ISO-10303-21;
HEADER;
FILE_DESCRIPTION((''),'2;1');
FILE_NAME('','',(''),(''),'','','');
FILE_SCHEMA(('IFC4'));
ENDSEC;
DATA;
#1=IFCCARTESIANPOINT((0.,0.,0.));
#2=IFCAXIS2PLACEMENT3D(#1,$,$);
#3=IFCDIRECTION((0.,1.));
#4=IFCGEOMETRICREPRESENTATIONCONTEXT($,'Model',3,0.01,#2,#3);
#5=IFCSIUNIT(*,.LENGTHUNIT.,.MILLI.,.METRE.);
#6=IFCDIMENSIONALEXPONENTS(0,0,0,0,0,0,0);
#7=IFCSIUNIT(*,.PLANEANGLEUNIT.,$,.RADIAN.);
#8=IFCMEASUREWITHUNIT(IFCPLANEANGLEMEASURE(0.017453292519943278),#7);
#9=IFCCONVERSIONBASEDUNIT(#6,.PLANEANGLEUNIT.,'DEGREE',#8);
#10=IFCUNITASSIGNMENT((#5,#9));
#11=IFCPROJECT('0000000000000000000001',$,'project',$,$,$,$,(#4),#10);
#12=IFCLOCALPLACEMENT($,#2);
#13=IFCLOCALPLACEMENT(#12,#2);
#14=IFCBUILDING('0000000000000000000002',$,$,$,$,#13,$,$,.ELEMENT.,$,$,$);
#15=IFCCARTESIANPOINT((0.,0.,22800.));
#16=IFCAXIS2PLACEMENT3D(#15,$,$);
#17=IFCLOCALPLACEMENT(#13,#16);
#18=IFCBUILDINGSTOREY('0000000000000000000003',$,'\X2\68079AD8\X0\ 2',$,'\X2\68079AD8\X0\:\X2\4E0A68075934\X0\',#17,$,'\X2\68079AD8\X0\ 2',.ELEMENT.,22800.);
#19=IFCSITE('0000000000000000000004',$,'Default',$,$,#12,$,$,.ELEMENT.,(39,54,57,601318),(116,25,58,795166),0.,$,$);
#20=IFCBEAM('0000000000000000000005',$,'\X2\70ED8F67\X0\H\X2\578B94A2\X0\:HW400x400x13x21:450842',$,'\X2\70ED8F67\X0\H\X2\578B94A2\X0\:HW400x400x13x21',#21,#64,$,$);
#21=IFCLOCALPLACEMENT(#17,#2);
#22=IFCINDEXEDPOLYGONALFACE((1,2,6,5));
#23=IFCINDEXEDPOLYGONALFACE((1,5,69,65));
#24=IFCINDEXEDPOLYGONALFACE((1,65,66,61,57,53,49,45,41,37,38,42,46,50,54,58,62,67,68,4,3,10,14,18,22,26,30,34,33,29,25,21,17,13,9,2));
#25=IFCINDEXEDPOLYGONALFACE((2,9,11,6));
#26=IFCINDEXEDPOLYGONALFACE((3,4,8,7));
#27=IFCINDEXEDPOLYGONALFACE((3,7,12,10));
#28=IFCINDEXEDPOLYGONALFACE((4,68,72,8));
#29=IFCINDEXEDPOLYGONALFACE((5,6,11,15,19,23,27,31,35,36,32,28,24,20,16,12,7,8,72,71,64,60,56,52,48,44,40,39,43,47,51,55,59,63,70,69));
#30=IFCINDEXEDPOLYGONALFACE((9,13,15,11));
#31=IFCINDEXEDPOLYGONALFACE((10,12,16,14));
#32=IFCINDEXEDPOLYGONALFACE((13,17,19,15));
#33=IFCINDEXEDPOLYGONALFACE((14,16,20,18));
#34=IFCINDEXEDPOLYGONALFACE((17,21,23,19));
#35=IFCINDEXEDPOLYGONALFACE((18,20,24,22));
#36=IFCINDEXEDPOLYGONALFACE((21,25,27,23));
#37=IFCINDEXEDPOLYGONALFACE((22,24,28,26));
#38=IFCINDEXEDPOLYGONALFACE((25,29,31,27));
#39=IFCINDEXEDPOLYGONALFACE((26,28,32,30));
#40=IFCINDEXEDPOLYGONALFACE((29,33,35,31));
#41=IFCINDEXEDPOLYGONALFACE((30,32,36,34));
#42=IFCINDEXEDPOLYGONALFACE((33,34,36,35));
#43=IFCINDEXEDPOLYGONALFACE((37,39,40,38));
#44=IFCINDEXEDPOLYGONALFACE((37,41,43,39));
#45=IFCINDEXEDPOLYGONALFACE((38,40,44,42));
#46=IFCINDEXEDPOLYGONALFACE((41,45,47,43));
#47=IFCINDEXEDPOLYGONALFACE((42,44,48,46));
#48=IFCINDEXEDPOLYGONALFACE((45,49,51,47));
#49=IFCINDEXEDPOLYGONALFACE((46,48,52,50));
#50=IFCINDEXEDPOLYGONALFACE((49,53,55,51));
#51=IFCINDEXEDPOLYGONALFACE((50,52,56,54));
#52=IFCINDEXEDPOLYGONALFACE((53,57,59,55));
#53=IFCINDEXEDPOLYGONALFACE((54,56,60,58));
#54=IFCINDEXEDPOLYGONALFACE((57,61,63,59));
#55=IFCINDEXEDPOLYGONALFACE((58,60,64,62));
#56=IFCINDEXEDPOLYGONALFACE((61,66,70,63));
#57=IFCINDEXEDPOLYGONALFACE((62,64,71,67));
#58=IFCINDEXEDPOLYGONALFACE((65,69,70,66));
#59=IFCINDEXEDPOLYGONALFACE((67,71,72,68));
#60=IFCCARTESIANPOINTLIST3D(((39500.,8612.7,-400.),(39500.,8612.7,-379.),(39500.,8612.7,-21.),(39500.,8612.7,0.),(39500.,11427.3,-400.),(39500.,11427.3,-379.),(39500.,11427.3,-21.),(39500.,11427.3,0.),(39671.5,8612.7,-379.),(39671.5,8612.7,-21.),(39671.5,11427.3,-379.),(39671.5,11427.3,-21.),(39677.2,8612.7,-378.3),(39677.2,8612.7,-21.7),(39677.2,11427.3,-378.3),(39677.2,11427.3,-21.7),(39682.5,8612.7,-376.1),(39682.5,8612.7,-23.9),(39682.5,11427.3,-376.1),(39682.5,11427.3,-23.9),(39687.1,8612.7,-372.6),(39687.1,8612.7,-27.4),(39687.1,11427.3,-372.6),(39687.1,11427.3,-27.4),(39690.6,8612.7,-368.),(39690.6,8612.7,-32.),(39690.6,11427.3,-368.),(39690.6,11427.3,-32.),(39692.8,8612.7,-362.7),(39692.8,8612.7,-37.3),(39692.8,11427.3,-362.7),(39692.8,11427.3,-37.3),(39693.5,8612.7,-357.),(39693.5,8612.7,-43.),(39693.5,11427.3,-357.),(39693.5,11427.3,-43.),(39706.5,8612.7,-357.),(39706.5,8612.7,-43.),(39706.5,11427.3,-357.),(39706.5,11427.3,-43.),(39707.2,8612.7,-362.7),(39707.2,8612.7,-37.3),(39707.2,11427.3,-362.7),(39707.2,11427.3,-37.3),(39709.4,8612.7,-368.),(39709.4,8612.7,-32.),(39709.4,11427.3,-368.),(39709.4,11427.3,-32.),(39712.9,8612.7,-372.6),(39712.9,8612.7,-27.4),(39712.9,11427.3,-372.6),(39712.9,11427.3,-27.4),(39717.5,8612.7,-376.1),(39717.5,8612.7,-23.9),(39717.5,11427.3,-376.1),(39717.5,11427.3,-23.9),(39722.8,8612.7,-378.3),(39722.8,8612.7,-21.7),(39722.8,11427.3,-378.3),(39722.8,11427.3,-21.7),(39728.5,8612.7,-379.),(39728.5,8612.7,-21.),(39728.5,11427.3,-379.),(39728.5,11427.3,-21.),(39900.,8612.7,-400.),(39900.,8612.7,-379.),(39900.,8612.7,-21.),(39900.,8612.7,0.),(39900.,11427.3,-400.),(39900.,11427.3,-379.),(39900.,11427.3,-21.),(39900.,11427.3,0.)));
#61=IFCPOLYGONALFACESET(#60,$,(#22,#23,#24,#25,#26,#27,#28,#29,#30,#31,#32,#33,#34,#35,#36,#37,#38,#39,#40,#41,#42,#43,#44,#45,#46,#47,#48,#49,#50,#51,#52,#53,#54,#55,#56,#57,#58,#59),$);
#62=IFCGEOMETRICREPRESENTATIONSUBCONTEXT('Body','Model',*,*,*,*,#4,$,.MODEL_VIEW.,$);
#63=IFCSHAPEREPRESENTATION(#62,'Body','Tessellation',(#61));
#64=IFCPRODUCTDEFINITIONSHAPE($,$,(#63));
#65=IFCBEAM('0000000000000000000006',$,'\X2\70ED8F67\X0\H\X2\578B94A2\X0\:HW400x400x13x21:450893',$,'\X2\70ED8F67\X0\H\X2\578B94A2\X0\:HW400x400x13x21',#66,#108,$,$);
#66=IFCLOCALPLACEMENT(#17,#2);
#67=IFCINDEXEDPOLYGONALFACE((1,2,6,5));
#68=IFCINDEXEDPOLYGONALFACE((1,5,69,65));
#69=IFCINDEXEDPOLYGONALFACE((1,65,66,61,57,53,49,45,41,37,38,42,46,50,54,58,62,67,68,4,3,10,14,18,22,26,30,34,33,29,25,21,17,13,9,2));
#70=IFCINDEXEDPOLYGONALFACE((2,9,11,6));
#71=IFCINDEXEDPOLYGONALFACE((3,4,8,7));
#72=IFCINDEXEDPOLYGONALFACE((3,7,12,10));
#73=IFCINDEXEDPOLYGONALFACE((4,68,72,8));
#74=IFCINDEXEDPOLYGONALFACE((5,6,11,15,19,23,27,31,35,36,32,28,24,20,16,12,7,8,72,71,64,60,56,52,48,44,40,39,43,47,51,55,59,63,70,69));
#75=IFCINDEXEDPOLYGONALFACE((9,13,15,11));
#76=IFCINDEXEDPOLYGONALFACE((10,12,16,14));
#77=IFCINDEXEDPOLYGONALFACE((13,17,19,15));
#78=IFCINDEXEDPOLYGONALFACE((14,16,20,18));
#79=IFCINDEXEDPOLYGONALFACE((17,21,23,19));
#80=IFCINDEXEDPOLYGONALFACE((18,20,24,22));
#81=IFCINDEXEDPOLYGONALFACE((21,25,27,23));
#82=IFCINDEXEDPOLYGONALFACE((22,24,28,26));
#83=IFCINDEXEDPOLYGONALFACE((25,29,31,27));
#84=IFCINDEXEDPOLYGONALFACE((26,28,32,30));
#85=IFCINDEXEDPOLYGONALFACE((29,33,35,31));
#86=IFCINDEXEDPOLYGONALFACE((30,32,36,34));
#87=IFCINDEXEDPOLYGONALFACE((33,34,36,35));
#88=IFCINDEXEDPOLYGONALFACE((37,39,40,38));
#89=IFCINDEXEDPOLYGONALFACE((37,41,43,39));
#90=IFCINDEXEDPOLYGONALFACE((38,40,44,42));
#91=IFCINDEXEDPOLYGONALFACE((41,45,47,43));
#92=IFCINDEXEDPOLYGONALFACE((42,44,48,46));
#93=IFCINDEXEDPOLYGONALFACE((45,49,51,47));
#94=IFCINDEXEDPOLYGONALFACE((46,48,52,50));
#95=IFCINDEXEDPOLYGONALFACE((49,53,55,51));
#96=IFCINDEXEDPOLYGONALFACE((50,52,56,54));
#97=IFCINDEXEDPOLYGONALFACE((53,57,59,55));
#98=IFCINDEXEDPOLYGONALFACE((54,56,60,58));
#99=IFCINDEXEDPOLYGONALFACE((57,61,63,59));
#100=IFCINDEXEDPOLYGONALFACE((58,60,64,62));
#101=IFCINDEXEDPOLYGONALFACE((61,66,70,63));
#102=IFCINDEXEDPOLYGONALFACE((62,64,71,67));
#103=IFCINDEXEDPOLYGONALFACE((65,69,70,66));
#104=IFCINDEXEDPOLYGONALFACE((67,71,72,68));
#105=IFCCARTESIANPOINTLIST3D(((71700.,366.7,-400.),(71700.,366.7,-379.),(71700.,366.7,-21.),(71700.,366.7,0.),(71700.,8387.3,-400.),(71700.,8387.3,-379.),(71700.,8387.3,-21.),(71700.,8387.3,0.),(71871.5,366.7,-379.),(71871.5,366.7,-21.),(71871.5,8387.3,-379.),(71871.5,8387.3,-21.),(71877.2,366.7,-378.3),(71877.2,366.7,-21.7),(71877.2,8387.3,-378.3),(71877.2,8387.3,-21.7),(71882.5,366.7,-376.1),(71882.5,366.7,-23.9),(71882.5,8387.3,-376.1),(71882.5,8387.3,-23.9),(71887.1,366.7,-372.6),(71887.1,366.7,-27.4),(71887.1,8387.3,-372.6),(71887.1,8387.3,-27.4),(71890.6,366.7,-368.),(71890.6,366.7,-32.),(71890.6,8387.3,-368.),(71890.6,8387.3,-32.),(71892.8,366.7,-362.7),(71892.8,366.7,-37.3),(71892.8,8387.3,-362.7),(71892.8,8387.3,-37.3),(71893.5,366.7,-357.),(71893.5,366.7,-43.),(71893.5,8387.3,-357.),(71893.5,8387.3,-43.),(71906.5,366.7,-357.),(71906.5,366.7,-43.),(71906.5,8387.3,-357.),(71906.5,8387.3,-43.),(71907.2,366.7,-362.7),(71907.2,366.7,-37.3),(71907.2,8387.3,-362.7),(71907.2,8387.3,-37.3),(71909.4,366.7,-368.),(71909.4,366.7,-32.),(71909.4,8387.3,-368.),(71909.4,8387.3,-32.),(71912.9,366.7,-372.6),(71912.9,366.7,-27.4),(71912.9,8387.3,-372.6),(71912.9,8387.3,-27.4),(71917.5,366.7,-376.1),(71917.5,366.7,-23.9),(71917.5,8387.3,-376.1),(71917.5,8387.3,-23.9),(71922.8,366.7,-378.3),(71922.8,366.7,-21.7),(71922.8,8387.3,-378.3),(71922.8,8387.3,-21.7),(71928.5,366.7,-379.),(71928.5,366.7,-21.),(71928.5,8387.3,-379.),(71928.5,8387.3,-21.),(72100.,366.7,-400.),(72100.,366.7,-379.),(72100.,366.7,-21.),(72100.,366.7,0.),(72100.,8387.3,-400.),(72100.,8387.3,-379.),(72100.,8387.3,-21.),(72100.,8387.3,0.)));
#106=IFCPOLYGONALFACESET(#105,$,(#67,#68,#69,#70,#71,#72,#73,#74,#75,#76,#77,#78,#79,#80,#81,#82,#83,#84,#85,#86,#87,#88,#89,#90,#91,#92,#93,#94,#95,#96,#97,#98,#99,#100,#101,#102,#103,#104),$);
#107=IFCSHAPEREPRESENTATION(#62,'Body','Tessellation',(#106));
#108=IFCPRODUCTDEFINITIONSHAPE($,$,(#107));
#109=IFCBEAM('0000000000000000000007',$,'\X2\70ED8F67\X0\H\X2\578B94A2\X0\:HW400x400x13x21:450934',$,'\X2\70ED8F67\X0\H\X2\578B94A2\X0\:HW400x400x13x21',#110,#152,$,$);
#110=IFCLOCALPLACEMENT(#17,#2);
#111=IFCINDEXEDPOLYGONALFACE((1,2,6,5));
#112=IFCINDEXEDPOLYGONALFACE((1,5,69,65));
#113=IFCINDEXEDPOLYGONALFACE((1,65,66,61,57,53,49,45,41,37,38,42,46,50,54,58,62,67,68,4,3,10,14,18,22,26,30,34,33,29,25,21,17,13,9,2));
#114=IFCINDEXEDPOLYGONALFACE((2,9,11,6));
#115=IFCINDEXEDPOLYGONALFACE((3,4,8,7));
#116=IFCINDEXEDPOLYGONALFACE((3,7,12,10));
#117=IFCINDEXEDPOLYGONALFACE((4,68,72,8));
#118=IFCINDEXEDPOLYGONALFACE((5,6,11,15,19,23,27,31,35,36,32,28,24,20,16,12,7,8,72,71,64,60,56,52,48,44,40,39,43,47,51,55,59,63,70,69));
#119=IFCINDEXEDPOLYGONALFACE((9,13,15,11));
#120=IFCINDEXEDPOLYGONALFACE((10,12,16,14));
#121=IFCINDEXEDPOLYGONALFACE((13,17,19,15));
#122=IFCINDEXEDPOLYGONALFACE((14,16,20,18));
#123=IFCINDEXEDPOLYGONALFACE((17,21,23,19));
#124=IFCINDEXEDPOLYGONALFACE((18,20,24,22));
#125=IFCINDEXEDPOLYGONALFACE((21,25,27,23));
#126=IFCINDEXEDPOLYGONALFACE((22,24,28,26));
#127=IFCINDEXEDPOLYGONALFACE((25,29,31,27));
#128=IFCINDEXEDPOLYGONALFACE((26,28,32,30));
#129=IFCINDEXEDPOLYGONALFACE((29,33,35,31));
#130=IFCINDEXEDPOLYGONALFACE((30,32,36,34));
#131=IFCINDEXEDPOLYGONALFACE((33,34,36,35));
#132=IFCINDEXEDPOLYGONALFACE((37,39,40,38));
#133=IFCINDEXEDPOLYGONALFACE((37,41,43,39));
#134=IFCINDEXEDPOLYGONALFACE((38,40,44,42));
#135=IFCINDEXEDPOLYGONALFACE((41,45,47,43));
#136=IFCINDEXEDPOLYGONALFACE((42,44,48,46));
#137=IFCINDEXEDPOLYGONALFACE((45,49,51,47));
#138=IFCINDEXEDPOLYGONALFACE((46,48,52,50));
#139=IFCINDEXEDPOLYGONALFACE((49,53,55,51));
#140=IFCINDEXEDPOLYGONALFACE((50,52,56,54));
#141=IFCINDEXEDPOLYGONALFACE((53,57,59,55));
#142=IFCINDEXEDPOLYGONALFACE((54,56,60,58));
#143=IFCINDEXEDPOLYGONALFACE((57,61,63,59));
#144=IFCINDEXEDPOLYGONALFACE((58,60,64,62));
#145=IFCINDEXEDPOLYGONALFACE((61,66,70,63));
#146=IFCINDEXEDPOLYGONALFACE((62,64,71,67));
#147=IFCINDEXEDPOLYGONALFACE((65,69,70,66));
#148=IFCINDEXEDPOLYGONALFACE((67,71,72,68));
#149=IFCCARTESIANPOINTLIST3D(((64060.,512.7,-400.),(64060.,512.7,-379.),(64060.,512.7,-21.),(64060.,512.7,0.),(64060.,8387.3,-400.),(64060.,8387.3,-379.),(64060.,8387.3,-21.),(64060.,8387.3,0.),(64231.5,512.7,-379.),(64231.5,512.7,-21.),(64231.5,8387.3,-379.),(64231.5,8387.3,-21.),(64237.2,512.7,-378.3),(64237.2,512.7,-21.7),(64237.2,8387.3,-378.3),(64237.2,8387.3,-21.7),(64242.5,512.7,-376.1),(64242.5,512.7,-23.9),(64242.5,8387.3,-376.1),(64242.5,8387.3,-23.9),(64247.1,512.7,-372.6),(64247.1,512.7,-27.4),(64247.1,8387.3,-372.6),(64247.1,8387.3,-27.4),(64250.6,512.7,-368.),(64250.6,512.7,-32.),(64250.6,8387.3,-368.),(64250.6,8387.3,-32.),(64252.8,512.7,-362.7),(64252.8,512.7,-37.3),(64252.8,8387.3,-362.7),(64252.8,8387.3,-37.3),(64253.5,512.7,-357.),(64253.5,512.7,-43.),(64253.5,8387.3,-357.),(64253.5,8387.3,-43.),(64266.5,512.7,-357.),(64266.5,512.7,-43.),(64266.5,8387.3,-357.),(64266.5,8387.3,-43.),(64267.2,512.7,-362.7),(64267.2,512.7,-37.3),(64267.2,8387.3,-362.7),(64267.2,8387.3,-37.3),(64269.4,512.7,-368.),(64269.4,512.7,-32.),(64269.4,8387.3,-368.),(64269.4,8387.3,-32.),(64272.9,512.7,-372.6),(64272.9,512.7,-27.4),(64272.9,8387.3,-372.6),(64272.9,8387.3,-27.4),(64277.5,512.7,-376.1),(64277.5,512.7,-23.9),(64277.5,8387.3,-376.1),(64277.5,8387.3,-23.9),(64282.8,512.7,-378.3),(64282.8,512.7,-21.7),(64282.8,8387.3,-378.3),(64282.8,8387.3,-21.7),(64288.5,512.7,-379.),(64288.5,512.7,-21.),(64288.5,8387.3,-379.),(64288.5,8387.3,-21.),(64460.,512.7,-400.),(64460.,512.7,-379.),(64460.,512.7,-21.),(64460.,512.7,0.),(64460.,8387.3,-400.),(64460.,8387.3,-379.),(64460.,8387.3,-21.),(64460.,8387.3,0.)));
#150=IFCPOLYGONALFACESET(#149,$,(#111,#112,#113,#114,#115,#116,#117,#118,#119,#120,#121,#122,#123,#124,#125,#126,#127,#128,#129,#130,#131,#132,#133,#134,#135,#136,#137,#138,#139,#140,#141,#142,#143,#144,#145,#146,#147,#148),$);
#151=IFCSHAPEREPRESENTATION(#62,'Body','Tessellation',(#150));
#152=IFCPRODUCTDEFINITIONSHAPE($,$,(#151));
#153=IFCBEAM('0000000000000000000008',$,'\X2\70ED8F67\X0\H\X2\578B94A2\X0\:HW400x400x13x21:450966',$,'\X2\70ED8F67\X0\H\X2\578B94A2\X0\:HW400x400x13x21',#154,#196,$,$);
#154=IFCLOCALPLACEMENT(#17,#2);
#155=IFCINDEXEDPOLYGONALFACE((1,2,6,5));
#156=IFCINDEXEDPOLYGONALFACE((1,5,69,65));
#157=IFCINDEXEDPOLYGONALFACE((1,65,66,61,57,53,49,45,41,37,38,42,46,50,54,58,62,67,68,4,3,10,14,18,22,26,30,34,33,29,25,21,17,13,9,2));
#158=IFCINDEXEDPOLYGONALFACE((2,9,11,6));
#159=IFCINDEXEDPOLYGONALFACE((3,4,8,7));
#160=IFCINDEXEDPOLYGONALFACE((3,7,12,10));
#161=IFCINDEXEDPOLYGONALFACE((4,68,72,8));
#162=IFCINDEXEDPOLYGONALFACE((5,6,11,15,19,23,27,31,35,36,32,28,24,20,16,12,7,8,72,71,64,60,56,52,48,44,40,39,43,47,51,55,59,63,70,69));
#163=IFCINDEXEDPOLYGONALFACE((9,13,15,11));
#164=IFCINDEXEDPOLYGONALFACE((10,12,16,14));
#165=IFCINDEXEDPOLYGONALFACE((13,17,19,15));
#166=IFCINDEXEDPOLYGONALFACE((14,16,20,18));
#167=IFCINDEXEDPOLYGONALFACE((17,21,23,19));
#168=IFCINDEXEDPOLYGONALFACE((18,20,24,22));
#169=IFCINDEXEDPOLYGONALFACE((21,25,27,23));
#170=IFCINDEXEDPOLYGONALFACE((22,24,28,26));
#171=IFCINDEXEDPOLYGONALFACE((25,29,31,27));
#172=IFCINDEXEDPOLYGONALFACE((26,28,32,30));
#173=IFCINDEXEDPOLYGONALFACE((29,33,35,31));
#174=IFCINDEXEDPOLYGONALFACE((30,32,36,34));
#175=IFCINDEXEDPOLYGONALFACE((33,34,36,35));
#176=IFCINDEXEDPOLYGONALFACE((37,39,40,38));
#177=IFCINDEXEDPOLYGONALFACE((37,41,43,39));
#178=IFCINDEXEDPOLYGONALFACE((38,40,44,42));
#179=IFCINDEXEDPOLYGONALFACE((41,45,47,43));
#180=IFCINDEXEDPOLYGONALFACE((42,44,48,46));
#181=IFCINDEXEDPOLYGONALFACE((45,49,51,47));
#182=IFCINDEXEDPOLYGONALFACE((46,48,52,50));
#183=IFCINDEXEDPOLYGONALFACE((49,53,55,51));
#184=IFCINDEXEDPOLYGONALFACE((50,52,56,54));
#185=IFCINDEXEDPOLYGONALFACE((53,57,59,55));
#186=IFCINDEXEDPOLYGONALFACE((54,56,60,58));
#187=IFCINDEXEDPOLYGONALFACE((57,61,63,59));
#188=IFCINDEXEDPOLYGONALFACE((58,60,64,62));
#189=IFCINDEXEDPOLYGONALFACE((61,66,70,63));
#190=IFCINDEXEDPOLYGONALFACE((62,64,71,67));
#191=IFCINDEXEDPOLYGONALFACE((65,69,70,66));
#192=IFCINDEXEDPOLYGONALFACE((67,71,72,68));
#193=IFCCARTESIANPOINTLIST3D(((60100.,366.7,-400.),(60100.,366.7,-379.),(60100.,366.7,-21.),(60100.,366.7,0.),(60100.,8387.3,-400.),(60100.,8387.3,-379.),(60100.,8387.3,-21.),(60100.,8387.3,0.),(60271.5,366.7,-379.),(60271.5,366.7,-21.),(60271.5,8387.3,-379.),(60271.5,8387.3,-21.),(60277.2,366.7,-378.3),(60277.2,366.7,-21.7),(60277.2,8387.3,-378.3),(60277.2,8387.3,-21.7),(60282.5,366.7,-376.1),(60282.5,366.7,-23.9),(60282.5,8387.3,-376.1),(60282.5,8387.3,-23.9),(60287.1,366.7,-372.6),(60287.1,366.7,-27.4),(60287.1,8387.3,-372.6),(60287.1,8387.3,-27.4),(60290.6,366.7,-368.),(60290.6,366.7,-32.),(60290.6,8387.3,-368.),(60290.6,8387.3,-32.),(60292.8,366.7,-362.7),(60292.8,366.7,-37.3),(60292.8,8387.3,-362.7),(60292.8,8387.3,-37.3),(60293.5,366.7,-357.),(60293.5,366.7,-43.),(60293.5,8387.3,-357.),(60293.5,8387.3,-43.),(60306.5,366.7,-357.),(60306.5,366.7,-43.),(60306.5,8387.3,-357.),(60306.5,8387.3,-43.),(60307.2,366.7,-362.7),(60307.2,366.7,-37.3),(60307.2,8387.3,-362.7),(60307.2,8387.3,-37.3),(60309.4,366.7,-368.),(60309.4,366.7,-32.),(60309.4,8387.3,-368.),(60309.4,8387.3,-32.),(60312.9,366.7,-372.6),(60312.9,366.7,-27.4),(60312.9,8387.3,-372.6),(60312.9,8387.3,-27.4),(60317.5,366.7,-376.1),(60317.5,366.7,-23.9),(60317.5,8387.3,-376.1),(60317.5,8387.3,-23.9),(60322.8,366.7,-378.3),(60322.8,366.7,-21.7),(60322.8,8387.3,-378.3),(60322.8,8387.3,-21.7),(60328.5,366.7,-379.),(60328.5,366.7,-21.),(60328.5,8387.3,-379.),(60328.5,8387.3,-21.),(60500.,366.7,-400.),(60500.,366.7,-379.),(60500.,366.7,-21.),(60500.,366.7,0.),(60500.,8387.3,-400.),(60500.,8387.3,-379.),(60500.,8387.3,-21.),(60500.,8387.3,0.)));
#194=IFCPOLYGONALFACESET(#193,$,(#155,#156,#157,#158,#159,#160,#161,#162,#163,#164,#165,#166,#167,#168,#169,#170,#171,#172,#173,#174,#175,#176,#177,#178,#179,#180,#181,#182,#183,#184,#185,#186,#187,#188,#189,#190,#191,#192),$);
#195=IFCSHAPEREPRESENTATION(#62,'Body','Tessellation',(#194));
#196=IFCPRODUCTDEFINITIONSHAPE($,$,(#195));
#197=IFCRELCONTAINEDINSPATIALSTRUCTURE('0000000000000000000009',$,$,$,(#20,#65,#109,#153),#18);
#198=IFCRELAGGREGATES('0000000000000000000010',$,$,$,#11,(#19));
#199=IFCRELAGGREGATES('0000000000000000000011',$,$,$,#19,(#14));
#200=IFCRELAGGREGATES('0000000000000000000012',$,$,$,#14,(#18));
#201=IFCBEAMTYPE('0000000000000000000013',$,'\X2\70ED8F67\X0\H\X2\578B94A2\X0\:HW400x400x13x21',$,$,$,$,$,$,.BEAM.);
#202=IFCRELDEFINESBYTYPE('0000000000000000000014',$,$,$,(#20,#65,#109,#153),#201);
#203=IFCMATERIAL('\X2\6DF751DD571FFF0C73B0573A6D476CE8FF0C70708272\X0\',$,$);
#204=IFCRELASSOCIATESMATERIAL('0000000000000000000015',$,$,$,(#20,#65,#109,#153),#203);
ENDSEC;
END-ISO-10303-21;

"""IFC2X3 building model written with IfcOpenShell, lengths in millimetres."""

from ifc_helpers import new_model, entity, si_unit, converted_unit, direction, frame, frame_2d, origin, place, context, subcontext, project, spatial, i_section, extrude, material, type_object, element, save


model = new_model("IFC2X3")

# Units and contexts
model_context = context("Model", 3, precision=0.01, world=origin(), true_north=direction((0.0, 1.0)))
body_context = subcontext(model_context, "Body", "Model", "MODEL_VIEW")
ifc_project = project(units=[si_unit("LENGTHUNIT", "METRE", prefix="MILLI"), converted_unit("PLANEANGLEUNIT", "DEGREE", entity("IfcPlaneAngleMeasure", 0.017453292519943278), si_unit("PLANEANGLEUNIT", "RADIAN"), dimensions=[0, 0, 0, 0, 0, 0, 0])], contexts=[model_context])

# Site, building, storey
site_placement = place(None, origin())
site = spatial("IfcSite", under=ifc_project, at=site_placement, Name="Default", CompositionType="ELEMENT", RefLatitude=(39, 54, 57, 601318), RefLongitude=(116, 25, 58, 795166), RefElevation=0.0)
building_placement = place(site_placement, origin())
building = spatial("IfcBuilding", under=site, at=building_placement, CompositionType="ELEMENT")
storey_placement = place(building_placement, frame((0.0, 0.0, 22800.0)))
storey = spatial("IfcBuildingStorey", under=building, at=storey_placement, Name="标高 2", ObjectType="标高:上标头", LongName="标高 2", CompositionType="ELEMENT", Elevation=22800.0)

# Beams
ifc_material = material(Name="混凝土，现场浇注，灰色")
beam_type = type_object("IfcBeamType", Name="热轧H型钢:HW400x400x13x21", PredefinedType="BEAM")
beam_1_placement = place(storey_placement, frame((39700.0, 11840.0, 0.0), z_axis=(0.0, 0.0, 1.0), x_axis=(0.0, -1.0, 0.0)))
element("IfcBeam", 1, at=beam_1_placement, inside=storey, type_object=beam_type, material=ifc_material, Name="热轧H型钢:HW400x400x13x21:450842", ObjectType="热轧H型钢:HW400x400x13x21", context=body_context, shape_type="SweptSolid", body=[
    extrude(i_section(OverallWidth=400.0, OverallDepth=400.0, WebThickness=13.0, FlangeThickness=21.0, FilletRadius=22.0, at=frame_2d((0.0, 0.0), x_axis=(0.0, 1.0))), frame((412.7, 0.0, -200.0), z_axis=(1.0, 0.0, 0.0), x_axis=(0.0, 0.0, -1.0)), (0.0, 0.0, 1.0), 2814.6),
])
beam_2_placement = place(storey_placement, frame((71900.0, 8600.0, 0.0), z_axis=(0.0, 0.0, 1.0), x_axis=(0.0, -1.0, 0.0)))
element("IfcBeam", 2, at=beam_2_placement, inside=storey, type_object=beam_type, material=ifc_material, Name="热轧H型钢:HW400x400x13x21:450893", ObjectType="热轧H型钢:HW400x400x13x21", context=body_context, shape_type="SweptSolid", body=[
    extrude(i_section(OverallWidth=400.0, OverallDepth=400.0, WebThickness=13.0, FlangeThickness=21.0, FilletRadius=22.0, at=frame_2d((0.0, 0.0), x_axis=(0.0, 1.0))), frame((212.7, 0.0, -200.0), z_axis=(1.0, 0.0, 0.0), x_axis=(0.0, 0.0, -1.0)), (0.0, 0.0, 1.0), 8020.6),
])
beam_3_placement = place(storey_placement, frame((64260.0, 100.0, 0.0), z_axis=(0.0, 0.0, 1.0), x_axis=(0.0, 1.0, 0.0)))
element("IfcBeam", 3, at=beam_3_placement, inside=storey, type_object=beam_type, material=ifc_material, Name="热轧H型钢:HW400x400x13x21:450934", ObjectType="热轧H型钢:HW400x400x13x21", context=body_context, shape_type="SweptSolid", body=[
    extrude(i_section(OverallWidth=400.0, OverallDepth=400.0, WebThickness=13.0, FlangeThickness=21.0, FilletRadius=22.0, at=frame_2d((0.0, 0.0), x_axis=(0.0, 1.0))), frame((412.7, 0.0, -200.0), z_axis=(1.0, 0.0, 0.0), x_axis=(0.0, 0.0, -1.0)), (0.0, 0.0, 1.0), 7874.6),
])
beam_4_placement = place(storey_placement, frame((60300.0, 8600.0, 0.0), z_axis=(0.0, 0.0, 1.0), x_axis=(0.0, -1.0, 0.0)))
element("IfcBeam", 4, at=beam_4_placement, inside=storey, type_object=beam_type, material=ifc_material, Name="热轧H型钢:HW400x400x13x21:450966", ObjectType="热轧H型钢:HW400x400x13x21", context=body_context, shape_type="SweptSolid", body=[
    extrude(i_section(OverallWidth=400.0, OverallDepth=400.0, WebThickness=13.0, FlangeThickness=21.0, FilletRadius=22.0, at=frame_2d((0.0, 0.0), x_axis=(0.0, 1.0))), frame((212.7, 0.0, -200.0), z_axis=(1.0, 0.0, 0.0), x_axis=(0.0, 0.0, -1.0)), (0.0, 0.0, 1.0), 8020.6),
])

save(model, "model.ifc")
